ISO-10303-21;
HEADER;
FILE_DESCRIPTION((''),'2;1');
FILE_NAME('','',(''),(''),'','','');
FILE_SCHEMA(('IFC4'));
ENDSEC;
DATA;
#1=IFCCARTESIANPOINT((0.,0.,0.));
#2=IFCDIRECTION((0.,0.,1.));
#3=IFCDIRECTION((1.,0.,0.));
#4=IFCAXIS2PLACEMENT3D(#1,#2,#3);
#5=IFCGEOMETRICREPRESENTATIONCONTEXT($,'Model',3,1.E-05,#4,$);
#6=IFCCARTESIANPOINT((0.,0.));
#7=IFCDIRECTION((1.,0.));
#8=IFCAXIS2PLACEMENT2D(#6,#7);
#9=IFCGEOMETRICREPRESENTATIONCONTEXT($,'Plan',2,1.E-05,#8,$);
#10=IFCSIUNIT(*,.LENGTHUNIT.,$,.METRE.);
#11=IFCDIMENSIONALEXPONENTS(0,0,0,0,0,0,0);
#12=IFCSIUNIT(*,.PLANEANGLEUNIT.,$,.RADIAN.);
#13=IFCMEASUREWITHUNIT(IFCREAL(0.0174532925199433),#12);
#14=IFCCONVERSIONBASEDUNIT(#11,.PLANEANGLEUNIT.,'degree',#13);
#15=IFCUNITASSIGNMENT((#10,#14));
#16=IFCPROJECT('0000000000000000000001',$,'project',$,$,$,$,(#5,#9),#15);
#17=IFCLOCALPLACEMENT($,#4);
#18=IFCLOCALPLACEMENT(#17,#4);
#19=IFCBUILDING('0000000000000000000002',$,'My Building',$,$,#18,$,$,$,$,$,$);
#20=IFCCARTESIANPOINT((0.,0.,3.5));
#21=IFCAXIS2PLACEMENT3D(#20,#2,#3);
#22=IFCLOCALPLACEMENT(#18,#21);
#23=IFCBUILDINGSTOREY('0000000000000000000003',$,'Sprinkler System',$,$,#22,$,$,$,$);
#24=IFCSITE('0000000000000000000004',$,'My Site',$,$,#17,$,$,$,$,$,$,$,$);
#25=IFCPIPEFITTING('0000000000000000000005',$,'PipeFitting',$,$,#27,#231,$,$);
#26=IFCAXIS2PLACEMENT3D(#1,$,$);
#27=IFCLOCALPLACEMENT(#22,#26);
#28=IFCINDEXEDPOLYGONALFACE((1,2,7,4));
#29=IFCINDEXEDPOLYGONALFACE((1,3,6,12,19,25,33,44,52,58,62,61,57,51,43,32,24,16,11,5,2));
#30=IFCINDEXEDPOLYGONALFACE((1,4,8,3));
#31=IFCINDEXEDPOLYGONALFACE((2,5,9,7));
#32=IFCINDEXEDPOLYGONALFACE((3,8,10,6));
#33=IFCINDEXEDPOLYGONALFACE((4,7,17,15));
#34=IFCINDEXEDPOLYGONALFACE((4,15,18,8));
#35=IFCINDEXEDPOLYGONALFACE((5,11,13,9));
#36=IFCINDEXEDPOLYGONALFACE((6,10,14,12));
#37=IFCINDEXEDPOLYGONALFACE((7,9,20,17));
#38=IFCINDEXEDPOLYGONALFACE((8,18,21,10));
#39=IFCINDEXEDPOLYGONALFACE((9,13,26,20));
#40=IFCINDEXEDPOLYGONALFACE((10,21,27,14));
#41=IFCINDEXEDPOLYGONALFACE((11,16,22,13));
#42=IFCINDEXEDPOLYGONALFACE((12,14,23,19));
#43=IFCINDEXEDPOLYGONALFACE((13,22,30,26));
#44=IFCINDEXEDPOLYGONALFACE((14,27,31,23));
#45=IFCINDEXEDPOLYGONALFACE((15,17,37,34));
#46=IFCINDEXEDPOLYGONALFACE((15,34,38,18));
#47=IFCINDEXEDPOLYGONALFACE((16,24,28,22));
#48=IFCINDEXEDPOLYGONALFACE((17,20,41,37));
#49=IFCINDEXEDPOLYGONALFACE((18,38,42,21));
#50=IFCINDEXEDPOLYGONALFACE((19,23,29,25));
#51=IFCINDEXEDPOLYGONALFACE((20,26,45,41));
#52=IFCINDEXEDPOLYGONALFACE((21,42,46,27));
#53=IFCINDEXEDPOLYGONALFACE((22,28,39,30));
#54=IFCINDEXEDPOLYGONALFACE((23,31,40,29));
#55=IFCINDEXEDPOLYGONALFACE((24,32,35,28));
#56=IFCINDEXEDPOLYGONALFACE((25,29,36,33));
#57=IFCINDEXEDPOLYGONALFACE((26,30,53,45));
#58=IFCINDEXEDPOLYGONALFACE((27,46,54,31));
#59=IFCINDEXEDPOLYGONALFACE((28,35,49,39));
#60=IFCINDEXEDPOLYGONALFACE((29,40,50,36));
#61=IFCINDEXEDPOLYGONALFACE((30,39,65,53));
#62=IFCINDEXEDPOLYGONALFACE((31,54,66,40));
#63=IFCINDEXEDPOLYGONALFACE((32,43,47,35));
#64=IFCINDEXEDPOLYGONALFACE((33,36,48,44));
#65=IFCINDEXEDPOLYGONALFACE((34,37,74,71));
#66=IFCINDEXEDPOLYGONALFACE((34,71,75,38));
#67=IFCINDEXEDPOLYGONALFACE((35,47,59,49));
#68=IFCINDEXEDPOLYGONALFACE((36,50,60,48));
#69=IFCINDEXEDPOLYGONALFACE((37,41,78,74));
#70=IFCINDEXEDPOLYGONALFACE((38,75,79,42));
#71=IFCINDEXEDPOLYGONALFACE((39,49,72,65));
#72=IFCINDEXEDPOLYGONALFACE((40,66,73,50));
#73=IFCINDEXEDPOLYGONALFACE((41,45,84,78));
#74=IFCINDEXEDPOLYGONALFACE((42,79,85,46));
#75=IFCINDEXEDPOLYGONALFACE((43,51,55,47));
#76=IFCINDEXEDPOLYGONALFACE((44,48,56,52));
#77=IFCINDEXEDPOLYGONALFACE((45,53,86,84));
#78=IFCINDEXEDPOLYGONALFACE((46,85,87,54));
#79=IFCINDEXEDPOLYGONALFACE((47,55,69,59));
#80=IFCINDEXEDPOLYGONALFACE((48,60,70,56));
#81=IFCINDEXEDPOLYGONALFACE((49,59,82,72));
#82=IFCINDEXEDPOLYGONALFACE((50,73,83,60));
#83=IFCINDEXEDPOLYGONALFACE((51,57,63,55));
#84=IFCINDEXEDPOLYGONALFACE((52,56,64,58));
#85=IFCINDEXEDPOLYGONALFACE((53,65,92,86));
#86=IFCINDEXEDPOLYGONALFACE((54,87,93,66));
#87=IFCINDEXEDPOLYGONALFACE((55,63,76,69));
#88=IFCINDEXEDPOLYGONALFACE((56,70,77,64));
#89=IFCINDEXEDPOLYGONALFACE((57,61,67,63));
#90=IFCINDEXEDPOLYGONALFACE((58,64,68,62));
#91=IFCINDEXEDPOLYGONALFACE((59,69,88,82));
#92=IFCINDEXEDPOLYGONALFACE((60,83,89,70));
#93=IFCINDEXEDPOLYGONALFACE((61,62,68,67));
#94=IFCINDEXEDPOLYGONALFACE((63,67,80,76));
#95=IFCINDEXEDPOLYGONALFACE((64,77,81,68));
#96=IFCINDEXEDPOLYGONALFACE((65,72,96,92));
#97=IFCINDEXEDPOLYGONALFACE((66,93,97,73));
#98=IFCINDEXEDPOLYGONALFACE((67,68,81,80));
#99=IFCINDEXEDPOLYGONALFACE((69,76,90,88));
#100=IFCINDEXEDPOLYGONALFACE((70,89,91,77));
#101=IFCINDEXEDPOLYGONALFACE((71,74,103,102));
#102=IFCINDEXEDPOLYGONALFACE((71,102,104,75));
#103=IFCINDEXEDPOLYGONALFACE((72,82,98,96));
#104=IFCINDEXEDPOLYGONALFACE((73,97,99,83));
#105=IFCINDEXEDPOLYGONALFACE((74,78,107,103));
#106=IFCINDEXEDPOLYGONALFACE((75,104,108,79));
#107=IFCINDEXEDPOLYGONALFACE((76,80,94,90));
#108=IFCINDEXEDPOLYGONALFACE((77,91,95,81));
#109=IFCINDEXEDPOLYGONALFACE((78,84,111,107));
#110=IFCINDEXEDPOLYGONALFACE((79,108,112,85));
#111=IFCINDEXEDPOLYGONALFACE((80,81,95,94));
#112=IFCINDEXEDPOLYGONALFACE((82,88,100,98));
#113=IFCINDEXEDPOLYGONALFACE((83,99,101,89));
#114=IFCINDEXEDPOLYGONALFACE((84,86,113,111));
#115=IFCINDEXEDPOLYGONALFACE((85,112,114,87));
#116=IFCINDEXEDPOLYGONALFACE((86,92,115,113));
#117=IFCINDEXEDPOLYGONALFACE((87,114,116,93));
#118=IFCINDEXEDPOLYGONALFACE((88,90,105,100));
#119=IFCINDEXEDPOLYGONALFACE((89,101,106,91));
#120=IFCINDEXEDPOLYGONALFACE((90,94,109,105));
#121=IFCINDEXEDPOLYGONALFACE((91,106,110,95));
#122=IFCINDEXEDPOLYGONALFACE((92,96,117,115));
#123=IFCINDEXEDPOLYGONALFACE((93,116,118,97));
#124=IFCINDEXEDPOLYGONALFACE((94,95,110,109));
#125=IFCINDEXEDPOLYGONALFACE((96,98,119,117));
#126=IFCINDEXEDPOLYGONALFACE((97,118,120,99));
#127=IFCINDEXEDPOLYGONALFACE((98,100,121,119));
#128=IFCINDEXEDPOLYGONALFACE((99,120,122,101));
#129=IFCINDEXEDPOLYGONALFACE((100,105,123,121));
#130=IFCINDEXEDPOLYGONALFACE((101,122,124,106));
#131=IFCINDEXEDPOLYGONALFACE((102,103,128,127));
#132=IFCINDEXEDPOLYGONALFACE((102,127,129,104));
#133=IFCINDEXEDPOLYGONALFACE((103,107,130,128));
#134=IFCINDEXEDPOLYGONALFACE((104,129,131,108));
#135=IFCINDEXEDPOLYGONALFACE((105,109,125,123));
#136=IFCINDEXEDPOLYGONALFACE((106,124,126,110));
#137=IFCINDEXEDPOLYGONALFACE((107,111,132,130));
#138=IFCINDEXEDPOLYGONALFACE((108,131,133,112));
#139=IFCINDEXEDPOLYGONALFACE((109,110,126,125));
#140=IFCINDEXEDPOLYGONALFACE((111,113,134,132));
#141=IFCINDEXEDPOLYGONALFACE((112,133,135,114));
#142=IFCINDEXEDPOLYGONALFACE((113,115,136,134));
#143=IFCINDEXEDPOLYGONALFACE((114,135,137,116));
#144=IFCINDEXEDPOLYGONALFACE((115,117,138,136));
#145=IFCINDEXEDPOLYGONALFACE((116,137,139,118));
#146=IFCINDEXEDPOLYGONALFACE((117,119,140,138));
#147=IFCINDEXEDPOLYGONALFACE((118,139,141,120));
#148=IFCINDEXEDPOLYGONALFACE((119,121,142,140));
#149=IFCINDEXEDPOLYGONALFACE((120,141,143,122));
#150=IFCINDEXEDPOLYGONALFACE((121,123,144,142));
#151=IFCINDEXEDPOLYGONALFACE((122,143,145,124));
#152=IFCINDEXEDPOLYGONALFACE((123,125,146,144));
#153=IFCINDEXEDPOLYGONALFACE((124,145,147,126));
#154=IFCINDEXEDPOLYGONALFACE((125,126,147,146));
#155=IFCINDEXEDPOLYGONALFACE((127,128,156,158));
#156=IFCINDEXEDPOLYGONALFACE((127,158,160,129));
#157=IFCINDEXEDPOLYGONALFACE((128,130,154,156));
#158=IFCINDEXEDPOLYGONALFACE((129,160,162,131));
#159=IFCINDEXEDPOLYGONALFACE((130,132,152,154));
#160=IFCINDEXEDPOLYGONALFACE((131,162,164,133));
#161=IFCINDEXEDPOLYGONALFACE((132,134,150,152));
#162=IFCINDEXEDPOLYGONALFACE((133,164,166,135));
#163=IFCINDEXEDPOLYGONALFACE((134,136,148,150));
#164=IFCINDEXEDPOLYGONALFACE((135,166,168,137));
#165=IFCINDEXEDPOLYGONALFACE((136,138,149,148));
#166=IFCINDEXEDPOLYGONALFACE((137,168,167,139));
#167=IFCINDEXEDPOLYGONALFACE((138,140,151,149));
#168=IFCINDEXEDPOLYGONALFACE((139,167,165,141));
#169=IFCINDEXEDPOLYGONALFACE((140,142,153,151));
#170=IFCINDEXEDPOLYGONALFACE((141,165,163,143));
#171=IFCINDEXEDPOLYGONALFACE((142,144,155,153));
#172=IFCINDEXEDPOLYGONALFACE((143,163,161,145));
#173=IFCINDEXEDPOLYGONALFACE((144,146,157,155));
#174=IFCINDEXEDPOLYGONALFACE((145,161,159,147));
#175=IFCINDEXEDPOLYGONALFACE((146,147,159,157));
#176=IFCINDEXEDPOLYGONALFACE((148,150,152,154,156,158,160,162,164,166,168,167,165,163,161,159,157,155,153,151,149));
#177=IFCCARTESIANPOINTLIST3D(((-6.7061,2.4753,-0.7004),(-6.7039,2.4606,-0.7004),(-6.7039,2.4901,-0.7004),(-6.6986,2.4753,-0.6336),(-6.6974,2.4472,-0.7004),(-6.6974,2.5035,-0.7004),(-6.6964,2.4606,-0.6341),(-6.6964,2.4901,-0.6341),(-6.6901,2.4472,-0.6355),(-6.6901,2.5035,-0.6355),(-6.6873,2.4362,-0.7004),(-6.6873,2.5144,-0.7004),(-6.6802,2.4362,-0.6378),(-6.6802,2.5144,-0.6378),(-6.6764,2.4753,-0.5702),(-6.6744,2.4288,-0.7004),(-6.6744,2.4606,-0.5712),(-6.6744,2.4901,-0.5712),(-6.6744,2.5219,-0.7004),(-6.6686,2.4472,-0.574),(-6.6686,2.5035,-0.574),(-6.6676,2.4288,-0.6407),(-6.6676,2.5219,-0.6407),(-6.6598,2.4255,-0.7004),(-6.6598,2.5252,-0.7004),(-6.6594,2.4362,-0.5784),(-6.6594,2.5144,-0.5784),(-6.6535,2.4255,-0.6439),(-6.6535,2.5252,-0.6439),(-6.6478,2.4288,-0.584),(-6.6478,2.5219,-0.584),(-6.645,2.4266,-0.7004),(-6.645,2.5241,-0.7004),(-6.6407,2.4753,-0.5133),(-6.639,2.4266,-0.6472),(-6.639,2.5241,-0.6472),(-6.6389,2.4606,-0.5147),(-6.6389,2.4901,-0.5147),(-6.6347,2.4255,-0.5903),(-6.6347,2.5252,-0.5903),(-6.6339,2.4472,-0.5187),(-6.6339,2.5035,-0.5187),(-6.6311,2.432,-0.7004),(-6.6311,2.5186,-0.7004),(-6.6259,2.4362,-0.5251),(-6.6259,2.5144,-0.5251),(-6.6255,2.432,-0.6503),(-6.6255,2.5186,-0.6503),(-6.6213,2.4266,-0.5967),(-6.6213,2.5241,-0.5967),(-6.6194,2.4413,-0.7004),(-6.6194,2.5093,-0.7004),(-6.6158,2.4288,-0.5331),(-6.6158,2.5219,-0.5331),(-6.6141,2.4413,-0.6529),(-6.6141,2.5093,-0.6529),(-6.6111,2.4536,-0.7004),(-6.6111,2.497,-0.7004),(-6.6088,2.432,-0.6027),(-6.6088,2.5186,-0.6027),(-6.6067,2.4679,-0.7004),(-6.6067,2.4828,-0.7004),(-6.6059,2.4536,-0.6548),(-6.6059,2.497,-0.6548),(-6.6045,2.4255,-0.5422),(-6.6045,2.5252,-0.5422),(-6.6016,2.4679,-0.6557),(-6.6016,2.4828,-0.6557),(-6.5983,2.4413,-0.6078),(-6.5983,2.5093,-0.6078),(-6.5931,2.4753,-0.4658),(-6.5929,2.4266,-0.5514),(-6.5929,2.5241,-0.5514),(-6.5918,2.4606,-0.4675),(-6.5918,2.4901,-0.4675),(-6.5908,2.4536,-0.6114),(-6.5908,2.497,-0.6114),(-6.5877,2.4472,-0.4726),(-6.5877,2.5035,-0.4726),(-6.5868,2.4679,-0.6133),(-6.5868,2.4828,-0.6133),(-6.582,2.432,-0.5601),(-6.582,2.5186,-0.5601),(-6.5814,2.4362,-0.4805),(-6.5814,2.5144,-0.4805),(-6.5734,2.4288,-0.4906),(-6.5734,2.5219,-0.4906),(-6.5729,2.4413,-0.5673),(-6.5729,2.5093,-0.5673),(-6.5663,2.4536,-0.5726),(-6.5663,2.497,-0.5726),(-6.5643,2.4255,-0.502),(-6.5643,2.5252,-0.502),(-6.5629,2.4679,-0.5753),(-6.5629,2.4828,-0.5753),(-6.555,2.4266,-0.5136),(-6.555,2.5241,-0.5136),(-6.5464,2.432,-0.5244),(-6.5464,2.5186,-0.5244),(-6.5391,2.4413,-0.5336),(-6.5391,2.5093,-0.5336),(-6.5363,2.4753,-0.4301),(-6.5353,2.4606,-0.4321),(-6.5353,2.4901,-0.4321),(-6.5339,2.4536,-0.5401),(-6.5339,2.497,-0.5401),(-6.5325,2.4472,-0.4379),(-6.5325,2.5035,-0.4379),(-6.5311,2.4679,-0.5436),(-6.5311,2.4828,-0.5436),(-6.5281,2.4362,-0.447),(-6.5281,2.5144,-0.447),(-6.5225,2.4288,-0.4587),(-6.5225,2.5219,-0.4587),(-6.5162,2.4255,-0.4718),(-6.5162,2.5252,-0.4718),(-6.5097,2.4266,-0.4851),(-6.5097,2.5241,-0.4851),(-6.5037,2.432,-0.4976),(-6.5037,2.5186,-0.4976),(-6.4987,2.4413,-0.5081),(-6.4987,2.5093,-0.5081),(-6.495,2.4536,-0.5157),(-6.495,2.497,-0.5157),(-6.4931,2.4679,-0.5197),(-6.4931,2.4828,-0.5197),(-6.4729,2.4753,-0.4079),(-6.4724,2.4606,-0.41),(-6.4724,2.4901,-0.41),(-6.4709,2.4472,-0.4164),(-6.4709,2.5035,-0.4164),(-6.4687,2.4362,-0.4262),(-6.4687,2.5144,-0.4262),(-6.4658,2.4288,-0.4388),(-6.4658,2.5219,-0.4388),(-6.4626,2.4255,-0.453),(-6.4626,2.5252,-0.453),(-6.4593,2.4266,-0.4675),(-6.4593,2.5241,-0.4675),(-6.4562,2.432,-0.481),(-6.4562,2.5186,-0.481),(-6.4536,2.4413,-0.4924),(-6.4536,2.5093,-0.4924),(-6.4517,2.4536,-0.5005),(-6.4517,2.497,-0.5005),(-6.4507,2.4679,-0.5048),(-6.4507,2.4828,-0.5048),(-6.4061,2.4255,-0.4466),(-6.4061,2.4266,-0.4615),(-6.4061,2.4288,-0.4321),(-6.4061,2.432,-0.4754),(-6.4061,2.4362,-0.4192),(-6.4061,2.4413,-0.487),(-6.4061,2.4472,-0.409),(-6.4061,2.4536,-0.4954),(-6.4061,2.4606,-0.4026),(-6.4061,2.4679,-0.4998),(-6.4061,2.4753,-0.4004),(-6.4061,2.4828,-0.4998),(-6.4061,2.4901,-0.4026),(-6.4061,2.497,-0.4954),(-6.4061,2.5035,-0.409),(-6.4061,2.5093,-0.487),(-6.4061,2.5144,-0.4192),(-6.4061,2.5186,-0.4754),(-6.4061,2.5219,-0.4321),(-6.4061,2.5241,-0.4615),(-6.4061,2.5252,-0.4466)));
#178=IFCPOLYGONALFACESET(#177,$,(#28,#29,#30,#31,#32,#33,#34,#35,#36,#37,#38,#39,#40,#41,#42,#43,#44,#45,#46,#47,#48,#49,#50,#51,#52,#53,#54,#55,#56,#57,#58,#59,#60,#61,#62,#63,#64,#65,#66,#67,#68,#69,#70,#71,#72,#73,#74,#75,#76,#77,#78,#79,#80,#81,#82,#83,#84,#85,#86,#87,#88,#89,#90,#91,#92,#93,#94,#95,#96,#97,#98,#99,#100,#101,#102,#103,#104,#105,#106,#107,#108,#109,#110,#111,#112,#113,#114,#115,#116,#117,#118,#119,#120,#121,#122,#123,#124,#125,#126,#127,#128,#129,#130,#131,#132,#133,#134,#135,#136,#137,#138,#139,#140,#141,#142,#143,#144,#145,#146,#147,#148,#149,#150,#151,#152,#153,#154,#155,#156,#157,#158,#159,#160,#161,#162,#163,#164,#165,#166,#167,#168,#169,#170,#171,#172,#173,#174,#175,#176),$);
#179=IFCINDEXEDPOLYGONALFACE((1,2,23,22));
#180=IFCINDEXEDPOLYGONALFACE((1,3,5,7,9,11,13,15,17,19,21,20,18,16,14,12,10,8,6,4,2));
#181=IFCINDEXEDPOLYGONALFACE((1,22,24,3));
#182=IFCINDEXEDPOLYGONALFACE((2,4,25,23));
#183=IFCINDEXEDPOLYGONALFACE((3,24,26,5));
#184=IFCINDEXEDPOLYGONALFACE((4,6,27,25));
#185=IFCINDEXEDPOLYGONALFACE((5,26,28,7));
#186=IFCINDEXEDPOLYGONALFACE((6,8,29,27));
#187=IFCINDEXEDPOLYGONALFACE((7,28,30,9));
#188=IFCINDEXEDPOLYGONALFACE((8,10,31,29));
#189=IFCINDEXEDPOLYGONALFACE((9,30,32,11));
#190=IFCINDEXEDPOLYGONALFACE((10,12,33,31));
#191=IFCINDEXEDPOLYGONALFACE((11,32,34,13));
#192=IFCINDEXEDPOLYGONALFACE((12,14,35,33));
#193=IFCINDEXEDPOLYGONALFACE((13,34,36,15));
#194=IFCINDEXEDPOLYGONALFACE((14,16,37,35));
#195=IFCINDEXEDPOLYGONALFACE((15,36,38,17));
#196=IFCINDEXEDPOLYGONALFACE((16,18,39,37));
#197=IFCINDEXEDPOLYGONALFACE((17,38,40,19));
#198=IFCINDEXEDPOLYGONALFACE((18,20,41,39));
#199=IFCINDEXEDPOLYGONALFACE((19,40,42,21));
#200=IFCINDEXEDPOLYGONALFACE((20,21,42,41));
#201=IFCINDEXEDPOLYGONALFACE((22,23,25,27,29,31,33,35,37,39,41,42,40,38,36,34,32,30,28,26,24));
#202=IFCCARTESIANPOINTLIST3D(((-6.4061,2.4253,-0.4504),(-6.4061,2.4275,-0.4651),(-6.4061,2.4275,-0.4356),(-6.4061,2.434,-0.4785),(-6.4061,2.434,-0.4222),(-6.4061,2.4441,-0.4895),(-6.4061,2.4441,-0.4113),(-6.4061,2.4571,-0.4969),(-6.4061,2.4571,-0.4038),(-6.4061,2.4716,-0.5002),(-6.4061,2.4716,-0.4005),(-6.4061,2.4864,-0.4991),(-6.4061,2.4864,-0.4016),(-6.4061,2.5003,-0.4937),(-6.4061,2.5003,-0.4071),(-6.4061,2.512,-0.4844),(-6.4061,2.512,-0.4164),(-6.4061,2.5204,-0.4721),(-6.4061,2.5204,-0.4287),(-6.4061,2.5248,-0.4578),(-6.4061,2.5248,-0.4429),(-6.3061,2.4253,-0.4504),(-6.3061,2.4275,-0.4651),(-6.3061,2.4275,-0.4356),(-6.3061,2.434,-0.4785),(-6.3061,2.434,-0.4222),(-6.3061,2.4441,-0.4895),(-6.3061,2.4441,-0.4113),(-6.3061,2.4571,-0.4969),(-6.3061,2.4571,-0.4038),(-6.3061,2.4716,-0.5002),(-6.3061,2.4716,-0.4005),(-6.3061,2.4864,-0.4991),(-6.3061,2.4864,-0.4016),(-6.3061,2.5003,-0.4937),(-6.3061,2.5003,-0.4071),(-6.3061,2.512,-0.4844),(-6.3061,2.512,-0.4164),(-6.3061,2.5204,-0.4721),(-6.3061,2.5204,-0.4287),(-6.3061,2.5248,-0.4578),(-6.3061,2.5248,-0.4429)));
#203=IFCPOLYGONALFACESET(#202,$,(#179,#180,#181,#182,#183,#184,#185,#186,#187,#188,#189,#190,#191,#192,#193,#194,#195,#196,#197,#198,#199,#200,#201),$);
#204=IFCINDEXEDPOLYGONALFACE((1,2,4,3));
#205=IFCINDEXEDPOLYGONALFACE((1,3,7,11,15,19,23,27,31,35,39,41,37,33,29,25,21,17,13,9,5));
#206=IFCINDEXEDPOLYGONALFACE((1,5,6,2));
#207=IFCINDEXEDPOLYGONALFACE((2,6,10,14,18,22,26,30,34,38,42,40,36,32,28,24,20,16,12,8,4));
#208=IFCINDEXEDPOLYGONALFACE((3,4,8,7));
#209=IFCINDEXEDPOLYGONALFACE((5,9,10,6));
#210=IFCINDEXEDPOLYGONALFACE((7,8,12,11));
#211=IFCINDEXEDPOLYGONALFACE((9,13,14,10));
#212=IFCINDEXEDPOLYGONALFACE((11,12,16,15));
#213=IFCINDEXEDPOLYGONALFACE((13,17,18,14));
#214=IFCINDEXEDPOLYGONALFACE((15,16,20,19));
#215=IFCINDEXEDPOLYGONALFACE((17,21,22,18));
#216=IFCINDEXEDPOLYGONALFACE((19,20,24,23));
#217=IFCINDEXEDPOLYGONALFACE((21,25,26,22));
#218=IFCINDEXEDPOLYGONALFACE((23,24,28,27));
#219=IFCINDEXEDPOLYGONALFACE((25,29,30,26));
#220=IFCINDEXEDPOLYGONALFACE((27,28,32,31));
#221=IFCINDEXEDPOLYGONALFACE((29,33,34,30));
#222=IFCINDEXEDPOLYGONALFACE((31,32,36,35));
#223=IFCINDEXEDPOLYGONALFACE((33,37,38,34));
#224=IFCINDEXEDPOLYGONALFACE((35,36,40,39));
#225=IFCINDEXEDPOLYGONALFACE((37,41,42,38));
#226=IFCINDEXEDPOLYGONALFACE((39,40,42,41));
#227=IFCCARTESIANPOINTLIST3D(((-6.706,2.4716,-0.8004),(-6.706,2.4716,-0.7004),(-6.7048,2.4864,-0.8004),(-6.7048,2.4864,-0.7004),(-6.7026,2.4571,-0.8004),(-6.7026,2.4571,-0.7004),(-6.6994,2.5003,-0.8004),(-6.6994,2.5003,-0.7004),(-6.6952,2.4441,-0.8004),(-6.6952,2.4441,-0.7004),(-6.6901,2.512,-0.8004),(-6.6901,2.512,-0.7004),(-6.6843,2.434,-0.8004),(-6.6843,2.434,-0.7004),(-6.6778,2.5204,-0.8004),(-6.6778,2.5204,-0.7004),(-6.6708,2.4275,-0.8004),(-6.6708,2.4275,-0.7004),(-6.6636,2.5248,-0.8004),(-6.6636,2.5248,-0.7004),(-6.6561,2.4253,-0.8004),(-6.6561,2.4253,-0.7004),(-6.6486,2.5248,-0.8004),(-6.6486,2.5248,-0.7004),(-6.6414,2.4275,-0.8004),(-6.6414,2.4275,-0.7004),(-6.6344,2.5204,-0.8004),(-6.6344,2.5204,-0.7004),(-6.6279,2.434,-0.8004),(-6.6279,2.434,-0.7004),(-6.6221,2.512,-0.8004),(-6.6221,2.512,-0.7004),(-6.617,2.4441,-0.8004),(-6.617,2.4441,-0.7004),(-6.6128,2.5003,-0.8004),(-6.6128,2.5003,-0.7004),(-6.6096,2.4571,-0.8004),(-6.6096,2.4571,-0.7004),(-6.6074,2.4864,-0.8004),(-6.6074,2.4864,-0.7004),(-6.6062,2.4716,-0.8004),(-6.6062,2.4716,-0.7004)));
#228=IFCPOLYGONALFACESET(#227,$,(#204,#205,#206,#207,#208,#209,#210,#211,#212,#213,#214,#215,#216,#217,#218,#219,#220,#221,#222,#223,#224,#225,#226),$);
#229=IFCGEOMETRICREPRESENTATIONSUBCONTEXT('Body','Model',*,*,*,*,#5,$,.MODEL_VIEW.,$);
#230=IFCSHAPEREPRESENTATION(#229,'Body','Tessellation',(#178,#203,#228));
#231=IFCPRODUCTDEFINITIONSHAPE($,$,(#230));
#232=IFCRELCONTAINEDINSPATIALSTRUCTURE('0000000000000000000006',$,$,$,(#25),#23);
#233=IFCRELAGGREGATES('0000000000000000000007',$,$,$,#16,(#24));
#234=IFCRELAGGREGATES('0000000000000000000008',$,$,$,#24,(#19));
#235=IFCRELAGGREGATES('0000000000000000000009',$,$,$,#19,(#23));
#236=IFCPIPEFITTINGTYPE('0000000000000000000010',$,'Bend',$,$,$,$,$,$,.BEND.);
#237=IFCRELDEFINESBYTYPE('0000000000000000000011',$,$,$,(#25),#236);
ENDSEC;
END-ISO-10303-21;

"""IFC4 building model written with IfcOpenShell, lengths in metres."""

from ifc_helpers import new_model, entity, si_unit, converted_unit, frame, origin_with_axes, origin_2d_with_axis, place, context, subcontext, project, spatial, circle, extrude, source, transform, mapped, type_object, type_shapes, element, save


model = new_model("IFC4")

# Units and contexts
model_context = context("Model", 3, precision=1e-05, world=origin_with_axes())
plan_context = context("Plan", 2, precision=1e-05, world=origin_2d_with_axis())
body_context = subcontext(model_context, "Body", "Model", "MODEL_VIEW")
ifc_project = project(units=[si_unit("LENGTHUNIT", "METRE"), converted_unit("PLANEANGLEUNIT", "degree", entity("IfcReal", 0.0174532925199433), si_unit("PLANEANGLEUNIT", "RADIAN"), dimensions=[0, 0, 0, 0, 0, 0, 0])], contexts=[model_context, plan_context])

# Site, building, storey
site_placement = place(None, origin_with_axes())
site = spatial("IfcSite", under=ifc_project, at=site_placement, Name="My Site")
building_placement = place(site_placement, origin_with_axes())
building = spatial("IfcBuilding", under=site, at=building_placement, Name="My Building")
storey_placement = place(building_placement, frame((0.0, 0.0, 3.5), z_axis=(0.0, 0.0, 1.0), x_axis=(1.0, 0.0, 0.0)))
storey = spatial("IfcBuildingStorey", under=building, at=storey_placement, Name="Sprinkler System")

# Pipe fitting
pipe_fitting_type_1 = type_object("IfcPipeFittingType", Name="Bend", PredefinedType="BEND")
shared_shape_1 = source(origin_with_axes(), body_context, "Body", "SolidModel", [
    entity("IfcSweptDiskSolid", entity("IfcIndexedPolyCurve", entity("IfcCartesianPointList3D", [[0.0, 0.0, 0.1], [0.0, -0.0732, 0.2768], [0.0, -0.25, 0.35]]), [entity("IfcArcIndex", [1, 2, 3])]), 0.05),
    extrude(circle(Radius=0.05), origin_with_axes(), (0.0, 0.0, 1.0), 0.1),
    extrude(circle(Radius=0.05), frame((0.0, -0.25, 0.35), z_axis=(0.0, -1.0, 0.0), x_axis=(1.0, 0.0, 0.0)), (0.0, 0.0, 1.0), 0.1),
])
type_shapes(pipe_fitting_type_1, [shared_shape_1])
for number, where, z_axis, x_axis, name in (
    (1, (-6.3061, 2.4753, -0.4504), (-1.0, 0.0, 0.0), (0.0, -1.0, 0.0), "PipeFitting"),
):
    element("IfcPipeFitting", number, at=place(storey_placement, frame(where, z_axis=z_axis, x_axis=x_axis)), inside=storey, type_object=pipe_fitting_type_1, Name=name, context=body_context, shape_type="MappedRepresentation", body=[
        mapped(shared_shape_1, transform((0.0, 0.0, 0.0), x_axis=(1.0, 0.0, 0.0), y_axis=(0.0, 1.0, 0.0), z_axis=(0.0, 0.0, 1.0), scale=1.0)),
    ])

save(model, "model.ifc")
